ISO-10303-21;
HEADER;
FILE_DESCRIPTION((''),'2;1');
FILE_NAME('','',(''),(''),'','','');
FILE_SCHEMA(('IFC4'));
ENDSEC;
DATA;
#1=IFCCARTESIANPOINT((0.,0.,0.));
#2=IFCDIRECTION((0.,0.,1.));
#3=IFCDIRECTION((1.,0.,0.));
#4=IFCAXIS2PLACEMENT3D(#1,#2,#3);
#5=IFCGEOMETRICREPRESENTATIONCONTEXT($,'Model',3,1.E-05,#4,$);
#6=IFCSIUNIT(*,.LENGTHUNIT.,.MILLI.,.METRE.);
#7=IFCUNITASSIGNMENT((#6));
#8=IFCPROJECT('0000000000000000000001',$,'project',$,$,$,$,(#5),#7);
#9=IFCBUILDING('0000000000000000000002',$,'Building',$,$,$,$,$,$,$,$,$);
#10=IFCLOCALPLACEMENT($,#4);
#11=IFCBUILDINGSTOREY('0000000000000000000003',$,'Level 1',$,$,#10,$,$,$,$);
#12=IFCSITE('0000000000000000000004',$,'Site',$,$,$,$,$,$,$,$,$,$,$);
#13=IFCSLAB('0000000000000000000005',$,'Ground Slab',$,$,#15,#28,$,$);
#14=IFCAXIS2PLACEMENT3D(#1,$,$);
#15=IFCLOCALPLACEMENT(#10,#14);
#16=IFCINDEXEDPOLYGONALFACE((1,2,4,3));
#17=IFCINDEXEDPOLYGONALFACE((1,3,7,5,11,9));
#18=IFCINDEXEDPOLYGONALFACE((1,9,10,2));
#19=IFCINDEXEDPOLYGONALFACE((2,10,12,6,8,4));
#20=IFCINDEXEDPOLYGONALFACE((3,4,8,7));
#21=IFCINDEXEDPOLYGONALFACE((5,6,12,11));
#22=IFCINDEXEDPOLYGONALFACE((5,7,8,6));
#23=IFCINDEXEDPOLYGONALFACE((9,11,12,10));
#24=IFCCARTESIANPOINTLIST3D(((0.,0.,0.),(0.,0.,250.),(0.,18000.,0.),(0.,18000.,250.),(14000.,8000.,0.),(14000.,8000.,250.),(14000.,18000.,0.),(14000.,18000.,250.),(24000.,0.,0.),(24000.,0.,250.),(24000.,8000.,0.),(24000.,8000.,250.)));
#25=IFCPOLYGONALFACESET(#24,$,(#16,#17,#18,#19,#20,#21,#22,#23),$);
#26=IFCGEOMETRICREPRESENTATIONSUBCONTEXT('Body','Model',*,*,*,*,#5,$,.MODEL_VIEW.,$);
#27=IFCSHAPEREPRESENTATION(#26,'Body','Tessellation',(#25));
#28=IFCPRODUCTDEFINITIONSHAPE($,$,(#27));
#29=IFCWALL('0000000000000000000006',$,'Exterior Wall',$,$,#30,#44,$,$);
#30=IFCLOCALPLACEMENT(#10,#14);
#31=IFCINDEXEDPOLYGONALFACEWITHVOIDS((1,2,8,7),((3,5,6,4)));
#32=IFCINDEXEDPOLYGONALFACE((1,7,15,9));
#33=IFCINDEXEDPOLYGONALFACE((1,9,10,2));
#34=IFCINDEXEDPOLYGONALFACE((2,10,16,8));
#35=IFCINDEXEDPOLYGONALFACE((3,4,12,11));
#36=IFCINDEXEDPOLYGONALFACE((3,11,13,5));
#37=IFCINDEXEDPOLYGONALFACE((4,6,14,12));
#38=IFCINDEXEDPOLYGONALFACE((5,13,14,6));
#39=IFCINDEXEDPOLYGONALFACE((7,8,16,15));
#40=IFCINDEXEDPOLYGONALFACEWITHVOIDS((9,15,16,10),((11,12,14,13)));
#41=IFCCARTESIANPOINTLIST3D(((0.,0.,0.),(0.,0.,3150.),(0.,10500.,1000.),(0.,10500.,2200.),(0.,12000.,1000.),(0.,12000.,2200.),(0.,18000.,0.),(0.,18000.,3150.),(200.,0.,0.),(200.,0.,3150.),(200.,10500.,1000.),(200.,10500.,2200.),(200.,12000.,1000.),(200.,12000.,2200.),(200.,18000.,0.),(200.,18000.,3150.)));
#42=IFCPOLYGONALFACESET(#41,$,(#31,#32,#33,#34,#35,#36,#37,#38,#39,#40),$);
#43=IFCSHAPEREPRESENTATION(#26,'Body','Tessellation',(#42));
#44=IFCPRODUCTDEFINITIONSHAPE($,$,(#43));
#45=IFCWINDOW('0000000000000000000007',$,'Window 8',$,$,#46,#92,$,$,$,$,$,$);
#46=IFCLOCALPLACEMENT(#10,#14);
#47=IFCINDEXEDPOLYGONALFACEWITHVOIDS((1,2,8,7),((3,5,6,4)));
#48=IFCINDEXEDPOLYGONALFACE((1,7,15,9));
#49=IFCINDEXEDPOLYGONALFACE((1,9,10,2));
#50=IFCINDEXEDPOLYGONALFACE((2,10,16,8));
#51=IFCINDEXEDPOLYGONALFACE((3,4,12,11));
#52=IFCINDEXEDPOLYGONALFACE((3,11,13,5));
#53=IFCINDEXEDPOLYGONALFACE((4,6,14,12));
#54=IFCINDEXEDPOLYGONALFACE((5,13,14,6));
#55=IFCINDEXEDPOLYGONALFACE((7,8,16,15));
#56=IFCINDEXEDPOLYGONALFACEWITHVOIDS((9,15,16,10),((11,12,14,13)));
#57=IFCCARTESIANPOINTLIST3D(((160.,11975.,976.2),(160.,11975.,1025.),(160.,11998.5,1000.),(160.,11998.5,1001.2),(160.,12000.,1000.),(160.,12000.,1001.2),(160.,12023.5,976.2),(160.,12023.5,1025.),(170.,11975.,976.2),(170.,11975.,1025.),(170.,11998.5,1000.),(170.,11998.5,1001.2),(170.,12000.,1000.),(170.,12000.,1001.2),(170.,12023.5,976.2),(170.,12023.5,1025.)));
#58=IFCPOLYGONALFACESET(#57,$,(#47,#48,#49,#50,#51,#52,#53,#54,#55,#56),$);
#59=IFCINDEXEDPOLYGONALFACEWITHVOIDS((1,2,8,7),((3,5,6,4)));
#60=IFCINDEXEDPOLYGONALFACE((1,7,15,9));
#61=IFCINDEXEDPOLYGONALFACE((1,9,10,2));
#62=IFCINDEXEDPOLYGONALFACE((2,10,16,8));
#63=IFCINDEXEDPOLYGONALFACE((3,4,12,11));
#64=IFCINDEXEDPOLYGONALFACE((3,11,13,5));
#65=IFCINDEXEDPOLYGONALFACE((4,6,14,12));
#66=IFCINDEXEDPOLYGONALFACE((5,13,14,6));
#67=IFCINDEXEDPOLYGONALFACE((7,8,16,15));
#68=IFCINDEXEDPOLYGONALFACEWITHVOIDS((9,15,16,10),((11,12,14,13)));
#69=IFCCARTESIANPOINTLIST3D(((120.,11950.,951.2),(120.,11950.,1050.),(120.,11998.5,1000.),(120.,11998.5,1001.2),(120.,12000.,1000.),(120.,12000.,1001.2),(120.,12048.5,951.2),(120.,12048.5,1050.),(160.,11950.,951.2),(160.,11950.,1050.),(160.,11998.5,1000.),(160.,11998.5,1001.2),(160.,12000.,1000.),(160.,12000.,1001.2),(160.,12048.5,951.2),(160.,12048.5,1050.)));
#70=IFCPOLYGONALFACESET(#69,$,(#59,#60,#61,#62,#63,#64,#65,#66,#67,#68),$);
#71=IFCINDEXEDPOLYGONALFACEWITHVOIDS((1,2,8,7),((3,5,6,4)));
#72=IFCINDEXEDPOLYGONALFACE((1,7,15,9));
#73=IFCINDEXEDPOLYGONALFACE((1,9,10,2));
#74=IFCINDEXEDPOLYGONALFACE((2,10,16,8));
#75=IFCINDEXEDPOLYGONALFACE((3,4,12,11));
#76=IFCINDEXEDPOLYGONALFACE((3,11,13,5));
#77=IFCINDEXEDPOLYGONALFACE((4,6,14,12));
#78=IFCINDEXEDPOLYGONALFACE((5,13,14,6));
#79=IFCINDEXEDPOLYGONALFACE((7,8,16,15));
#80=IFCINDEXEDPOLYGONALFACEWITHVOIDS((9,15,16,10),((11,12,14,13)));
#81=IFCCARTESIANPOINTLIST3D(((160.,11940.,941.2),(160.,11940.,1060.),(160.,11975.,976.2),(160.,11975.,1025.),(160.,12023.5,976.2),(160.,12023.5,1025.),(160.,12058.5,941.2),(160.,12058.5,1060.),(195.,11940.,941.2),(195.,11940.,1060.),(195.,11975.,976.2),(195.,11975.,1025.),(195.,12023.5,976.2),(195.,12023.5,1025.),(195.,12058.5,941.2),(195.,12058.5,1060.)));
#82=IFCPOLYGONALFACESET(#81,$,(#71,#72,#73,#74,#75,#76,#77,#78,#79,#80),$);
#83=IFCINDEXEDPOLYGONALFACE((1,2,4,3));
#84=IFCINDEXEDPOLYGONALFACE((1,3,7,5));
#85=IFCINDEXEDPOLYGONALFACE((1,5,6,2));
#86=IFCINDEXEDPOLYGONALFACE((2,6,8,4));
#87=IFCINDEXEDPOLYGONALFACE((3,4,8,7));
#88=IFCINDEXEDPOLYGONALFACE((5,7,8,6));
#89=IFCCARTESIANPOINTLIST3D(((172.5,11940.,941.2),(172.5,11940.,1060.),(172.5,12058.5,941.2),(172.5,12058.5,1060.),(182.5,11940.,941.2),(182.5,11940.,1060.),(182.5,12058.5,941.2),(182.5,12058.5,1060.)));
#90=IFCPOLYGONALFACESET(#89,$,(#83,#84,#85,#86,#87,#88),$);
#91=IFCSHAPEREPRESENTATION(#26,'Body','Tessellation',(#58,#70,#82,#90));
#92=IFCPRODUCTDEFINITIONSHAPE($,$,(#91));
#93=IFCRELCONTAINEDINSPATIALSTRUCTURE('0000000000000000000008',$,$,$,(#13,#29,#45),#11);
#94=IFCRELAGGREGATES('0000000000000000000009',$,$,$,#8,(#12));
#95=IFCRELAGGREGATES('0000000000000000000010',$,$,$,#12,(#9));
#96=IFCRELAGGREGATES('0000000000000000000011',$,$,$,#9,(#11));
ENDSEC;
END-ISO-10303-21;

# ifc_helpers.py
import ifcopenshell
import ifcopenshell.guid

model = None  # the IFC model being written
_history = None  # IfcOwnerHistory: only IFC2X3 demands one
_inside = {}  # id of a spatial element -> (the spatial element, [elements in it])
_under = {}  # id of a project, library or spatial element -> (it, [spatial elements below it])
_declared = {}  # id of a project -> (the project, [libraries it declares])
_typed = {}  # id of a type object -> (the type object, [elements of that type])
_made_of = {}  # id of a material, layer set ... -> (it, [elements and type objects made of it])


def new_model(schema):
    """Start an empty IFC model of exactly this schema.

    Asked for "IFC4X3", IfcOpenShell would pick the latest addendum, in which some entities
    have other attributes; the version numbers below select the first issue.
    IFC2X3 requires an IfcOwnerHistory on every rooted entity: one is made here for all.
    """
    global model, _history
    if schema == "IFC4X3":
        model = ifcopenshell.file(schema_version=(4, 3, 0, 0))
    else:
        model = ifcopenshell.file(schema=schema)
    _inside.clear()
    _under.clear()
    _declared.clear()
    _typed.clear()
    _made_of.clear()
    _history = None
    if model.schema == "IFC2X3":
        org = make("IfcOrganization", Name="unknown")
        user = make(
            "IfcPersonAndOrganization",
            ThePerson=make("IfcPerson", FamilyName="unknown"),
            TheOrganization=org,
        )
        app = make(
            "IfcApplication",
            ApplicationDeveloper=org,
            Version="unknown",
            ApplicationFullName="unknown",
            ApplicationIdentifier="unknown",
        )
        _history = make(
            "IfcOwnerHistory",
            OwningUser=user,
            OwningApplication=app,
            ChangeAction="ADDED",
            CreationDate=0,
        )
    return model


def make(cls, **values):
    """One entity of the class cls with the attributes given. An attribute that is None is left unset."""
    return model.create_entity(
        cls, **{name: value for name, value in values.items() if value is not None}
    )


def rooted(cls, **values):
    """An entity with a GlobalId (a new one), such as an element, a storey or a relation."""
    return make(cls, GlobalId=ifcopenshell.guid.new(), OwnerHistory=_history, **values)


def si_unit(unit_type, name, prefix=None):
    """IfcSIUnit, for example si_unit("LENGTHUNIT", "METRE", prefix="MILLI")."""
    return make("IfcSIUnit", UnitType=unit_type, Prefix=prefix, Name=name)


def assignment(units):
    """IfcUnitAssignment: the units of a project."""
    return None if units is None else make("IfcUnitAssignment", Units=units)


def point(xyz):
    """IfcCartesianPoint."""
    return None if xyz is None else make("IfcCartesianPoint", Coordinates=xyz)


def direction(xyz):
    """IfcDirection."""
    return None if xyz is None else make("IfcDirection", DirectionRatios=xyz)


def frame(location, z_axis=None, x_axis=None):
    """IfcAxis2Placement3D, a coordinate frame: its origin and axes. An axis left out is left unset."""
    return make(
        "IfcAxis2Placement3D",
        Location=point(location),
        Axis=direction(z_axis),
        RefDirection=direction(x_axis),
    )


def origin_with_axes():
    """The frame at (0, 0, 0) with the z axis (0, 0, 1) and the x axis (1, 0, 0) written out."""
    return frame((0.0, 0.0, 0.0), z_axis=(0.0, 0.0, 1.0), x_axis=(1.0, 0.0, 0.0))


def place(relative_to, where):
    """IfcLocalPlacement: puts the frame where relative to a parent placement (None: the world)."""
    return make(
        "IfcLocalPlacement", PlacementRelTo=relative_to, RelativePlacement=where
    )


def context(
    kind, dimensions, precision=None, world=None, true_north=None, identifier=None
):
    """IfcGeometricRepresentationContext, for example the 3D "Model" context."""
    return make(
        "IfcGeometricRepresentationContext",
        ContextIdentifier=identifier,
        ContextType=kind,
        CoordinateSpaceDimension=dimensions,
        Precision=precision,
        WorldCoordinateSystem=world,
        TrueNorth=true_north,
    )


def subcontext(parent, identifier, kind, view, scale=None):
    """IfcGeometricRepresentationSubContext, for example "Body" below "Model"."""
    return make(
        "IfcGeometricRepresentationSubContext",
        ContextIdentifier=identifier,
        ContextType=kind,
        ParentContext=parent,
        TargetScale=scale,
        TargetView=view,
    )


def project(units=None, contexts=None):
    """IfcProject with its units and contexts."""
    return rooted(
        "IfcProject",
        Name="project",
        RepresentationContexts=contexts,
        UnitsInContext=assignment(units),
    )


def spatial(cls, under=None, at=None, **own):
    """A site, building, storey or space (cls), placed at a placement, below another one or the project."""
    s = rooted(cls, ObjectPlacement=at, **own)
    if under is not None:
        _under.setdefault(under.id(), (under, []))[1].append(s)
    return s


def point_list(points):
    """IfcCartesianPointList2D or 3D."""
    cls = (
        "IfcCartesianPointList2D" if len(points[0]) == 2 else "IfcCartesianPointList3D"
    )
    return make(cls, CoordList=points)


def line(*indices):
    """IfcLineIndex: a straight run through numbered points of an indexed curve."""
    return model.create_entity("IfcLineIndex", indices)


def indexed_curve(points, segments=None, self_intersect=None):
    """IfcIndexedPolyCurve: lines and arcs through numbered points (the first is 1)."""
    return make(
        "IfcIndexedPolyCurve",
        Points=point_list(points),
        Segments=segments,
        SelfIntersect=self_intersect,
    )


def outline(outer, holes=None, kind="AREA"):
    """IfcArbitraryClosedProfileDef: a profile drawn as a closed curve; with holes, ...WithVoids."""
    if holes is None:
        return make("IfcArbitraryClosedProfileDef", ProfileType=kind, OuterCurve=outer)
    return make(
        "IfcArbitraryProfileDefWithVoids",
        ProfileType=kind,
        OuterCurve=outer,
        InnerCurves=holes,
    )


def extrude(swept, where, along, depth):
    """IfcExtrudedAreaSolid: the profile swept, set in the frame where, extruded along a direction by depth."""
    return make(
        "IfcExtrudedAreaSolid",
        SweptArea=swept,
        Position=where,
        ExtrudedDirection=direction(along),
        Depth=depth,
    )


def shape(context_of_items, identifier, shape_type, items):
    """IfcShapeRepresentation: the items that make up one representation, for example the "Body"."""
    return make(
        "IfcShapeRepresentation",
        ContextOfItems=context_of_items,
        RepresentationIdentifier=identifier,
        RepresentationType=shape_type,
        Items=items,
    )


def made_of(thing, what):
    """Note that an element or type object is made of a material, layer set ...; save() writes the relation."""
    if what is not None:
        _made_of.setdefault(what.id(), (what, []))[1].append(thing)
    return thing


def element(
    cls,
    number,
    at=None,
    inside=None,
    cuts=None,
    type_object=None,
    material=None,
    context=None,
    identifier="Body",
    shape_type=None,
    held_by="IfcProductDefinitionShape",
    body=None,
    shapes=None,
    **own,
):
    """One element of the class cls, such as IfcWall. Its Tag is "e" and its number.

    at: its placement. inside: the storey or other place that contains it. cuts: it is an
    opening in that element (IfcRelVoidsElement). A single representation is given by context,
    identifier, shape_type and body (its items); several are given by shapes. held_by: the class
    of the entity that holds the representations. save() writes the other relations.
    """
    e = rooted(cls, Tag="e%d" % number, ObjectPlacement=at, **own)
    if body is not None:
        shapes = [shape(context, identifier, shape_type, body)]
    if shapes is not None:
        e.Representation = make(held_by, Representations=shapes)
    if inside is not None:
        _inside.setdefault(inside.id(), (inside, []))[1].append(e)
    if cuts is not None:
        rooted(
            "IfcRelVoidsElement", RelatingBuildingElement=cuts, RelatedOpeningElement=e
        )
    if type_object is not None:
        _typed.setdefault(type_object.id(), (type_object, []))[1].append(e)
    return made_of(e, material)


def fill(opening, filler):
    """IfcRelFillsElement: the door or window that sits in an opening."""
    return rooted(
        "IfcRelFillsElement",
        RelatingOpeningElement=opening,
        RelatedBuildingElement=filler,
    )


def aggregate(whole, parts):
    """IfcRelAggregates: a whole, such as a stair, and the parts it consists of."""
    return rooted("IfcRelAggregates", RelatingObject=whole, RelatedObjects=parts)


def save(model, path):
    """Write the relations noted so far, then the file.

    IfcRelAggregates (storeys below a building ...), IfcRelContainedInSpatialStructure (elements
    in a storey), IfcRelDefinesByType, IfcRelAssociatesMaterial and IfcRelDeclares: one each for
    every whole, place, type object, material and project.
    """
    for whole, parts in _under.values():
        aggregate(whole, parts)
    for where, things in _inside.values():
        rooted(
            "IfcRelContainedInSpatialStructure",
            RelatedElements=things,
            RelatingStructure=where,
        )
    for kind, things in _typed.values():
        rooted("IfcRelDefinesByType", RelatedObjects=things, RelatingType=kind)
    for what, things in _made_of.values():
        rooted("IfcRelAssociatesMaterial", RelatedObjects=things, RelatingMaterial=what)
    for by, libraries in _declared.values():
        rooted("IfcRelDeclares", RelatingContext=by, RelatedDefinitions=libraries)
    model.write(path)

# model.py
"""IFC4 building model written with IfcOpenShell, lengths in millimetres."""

from ifc_helpers import new_model, si_unit, frame, origin_with_axes, place, context, subcontext, project, spatial, line, indexed_curve, outline, extrude, element, fill, save


model = new_model("IFC4")

# Units and contexts
model_context = context("Model", 3, precision=1e-05, world=origin_with_axes())
body_context = subcontext(model_context, "Body", "Model", "MODEL_VIEW")
ifc_project = project(units=[si_unit("LENGTHUNIT", "METRE", prefix="MILLI")], contexts=[model_context])

# Site, building, storey
site = spatial("IfcSite", under=ifc_project, Name="Site")
building = spatial("IfcBuilding", under=site, Name="Building")
storey_placement = place(None, origin_with_axes())
storey = spatial("IfcBuildingStorey", under=building, at=storey_placement, Name="Level 1")

# Slab
slab_placement = place(storey_placement, origin_with_axes())
element("IfcSlab", 1, at=slab_placement, inside=storey, Name="Ground Slab", context=body_context, shape_type="SweptSolid", body=[
    extrude(outline(indexed_curve([(0.0, 0.0), (24000.0, 0.0), (24000.0, 8000.0), (14000.0, 8000.0), (14000.0, 18000.0), (0.0, 18000.0), (0.0, 0.0)])), None, (0.0, 0.0, 1.0), 250.0),
])

# Wall, opening, window
wall_1_placement = place(storey_placement, frame((0.0, 18000.0, 0.0), z_axis=(0.0, 0.0, 1.0), x_axis=(0.0, -1.0, 0.0)))
wall_1 = element("IfcWall", 2, at=wall_1_placement, inside=storey, Name="Exterior Wall", context=body_context, shape_type="SweptSolid", body=[
    extrude(outline(indexed_curve([(0.0, 0.0), (0.0, 200.0), (18000.0, 200.0), (18000.0, 0.0), (0.0, 0.0)], self_intersect=False)), origin_with_axes(), (0.0, 0.0, 1.0), 3150.0),
])
opening_1_placement = place(wall_1_placement, frame((6000.0, -100.0, 1000.0), z_axis=(0.0, 0.0, 1.0), x_axis=(1.0, 0.0, 0.0)))
opening_1 = element("IfcOpeningElement", 3, at=opening_1_placement, cuts=wall_1, context=body_context, shape_type="SweptSolid", body=[
    extrude(outline(indexed_curve([(0.0, 0.0), (0.0, 400.0), (1500.0, 400.0), (1500.0, 0.0), (0.0, 0.0)], self_intersect=False)), origin_with_axes(), (0.0, 0.0, 1.0), 1200.0),
])
window_1_placement = place(opening_1_placement, frame((0.0, 170.0, 0.0), z_axis=(0.0, 0.0, 1.0), x_axis=(1.0, 0.0, 0.0)))
window_1 = element("IfcWindow", 4, at=window_1_placement, inside=storey, Name="Window 8", context=body_context, shape_type="SweptSolid", body=[
    extrude(outline(indexed_curve([(0.0, 0.0), (1.5, 0.0), (1.5, 1.2), (0.0, 1.2)], segments=[line(1, 2, 3, 4, 1)]), holes=[indexed_curve([(25.0, 25.0), (-23.5, 25.0), (-23.5, -23.8), (25.0, -23.8)], segments=[line(1, 2, 3, 4, 1)])]), frame((0.0, 90.0, 0.0), z_axis=(0.0, -1.0, 0.0), x_axis=(1.0, 0.0, 0.0)), (0.0, 0.0, -1.0), 10.0),
    extrude(outline(indexed_curve([(0.0, 0.0), (1.5, 0.0), (1.5, 1.2), (0.0, 1.2)], segments=[line(1, 2, 3, 4, 1)]), holes=[indexed_curve([(50.0, 50.0), (-48.5, 50.0), (-48.5, -48.8), (50.0, -48.8)], segments=[line(1, 2, 3, 4, 1)])]), frame((0.0, 50.0, 0.0), z_axis=(0.0, -1.0, 0.0), x_axis=(1.0, 0.0, 0.0)), (0.0, 0.0, -1.0), 40.0),
    extrude(outline(indexed_curve([(0.0, 0.0), (-48.5, 0.0), (-48.5, -48.8), (0.0, -48.8)], segments=[line(1, 2, 3, 4, 1)]), holes=[indexed_curve([(35.0, 35.0), (-83.5, 35.0), (-83.5, -83.8), (35.0, -83.8)], segments=[line(1, 2, 3, 4, 1)])]), frame((25.0, 90.0, 25.0), z_axis=(0.0, -1.0, 0.0), x_axis=(1.0, 0.0, 0.0)), (0.0, 0.0, -1.0), 35.0),
    extrude(outline(indexed_curve([(35.0, 35.0), (-83.5, 35.0), (-83.5, -83.8), (35.0, -83.8)], segments=[line(1, 2, 3, 4, 1)])), frame((25.0, 102.5, 25.0), z_axis=(0.0, -1.0, 0.0), x_axis=(1.0, 0.0, 0.0)), (0.0, 0.0, -1.0), 10.0),
])
fill(opening_1, window_1)

save(model, "model.ifc")
